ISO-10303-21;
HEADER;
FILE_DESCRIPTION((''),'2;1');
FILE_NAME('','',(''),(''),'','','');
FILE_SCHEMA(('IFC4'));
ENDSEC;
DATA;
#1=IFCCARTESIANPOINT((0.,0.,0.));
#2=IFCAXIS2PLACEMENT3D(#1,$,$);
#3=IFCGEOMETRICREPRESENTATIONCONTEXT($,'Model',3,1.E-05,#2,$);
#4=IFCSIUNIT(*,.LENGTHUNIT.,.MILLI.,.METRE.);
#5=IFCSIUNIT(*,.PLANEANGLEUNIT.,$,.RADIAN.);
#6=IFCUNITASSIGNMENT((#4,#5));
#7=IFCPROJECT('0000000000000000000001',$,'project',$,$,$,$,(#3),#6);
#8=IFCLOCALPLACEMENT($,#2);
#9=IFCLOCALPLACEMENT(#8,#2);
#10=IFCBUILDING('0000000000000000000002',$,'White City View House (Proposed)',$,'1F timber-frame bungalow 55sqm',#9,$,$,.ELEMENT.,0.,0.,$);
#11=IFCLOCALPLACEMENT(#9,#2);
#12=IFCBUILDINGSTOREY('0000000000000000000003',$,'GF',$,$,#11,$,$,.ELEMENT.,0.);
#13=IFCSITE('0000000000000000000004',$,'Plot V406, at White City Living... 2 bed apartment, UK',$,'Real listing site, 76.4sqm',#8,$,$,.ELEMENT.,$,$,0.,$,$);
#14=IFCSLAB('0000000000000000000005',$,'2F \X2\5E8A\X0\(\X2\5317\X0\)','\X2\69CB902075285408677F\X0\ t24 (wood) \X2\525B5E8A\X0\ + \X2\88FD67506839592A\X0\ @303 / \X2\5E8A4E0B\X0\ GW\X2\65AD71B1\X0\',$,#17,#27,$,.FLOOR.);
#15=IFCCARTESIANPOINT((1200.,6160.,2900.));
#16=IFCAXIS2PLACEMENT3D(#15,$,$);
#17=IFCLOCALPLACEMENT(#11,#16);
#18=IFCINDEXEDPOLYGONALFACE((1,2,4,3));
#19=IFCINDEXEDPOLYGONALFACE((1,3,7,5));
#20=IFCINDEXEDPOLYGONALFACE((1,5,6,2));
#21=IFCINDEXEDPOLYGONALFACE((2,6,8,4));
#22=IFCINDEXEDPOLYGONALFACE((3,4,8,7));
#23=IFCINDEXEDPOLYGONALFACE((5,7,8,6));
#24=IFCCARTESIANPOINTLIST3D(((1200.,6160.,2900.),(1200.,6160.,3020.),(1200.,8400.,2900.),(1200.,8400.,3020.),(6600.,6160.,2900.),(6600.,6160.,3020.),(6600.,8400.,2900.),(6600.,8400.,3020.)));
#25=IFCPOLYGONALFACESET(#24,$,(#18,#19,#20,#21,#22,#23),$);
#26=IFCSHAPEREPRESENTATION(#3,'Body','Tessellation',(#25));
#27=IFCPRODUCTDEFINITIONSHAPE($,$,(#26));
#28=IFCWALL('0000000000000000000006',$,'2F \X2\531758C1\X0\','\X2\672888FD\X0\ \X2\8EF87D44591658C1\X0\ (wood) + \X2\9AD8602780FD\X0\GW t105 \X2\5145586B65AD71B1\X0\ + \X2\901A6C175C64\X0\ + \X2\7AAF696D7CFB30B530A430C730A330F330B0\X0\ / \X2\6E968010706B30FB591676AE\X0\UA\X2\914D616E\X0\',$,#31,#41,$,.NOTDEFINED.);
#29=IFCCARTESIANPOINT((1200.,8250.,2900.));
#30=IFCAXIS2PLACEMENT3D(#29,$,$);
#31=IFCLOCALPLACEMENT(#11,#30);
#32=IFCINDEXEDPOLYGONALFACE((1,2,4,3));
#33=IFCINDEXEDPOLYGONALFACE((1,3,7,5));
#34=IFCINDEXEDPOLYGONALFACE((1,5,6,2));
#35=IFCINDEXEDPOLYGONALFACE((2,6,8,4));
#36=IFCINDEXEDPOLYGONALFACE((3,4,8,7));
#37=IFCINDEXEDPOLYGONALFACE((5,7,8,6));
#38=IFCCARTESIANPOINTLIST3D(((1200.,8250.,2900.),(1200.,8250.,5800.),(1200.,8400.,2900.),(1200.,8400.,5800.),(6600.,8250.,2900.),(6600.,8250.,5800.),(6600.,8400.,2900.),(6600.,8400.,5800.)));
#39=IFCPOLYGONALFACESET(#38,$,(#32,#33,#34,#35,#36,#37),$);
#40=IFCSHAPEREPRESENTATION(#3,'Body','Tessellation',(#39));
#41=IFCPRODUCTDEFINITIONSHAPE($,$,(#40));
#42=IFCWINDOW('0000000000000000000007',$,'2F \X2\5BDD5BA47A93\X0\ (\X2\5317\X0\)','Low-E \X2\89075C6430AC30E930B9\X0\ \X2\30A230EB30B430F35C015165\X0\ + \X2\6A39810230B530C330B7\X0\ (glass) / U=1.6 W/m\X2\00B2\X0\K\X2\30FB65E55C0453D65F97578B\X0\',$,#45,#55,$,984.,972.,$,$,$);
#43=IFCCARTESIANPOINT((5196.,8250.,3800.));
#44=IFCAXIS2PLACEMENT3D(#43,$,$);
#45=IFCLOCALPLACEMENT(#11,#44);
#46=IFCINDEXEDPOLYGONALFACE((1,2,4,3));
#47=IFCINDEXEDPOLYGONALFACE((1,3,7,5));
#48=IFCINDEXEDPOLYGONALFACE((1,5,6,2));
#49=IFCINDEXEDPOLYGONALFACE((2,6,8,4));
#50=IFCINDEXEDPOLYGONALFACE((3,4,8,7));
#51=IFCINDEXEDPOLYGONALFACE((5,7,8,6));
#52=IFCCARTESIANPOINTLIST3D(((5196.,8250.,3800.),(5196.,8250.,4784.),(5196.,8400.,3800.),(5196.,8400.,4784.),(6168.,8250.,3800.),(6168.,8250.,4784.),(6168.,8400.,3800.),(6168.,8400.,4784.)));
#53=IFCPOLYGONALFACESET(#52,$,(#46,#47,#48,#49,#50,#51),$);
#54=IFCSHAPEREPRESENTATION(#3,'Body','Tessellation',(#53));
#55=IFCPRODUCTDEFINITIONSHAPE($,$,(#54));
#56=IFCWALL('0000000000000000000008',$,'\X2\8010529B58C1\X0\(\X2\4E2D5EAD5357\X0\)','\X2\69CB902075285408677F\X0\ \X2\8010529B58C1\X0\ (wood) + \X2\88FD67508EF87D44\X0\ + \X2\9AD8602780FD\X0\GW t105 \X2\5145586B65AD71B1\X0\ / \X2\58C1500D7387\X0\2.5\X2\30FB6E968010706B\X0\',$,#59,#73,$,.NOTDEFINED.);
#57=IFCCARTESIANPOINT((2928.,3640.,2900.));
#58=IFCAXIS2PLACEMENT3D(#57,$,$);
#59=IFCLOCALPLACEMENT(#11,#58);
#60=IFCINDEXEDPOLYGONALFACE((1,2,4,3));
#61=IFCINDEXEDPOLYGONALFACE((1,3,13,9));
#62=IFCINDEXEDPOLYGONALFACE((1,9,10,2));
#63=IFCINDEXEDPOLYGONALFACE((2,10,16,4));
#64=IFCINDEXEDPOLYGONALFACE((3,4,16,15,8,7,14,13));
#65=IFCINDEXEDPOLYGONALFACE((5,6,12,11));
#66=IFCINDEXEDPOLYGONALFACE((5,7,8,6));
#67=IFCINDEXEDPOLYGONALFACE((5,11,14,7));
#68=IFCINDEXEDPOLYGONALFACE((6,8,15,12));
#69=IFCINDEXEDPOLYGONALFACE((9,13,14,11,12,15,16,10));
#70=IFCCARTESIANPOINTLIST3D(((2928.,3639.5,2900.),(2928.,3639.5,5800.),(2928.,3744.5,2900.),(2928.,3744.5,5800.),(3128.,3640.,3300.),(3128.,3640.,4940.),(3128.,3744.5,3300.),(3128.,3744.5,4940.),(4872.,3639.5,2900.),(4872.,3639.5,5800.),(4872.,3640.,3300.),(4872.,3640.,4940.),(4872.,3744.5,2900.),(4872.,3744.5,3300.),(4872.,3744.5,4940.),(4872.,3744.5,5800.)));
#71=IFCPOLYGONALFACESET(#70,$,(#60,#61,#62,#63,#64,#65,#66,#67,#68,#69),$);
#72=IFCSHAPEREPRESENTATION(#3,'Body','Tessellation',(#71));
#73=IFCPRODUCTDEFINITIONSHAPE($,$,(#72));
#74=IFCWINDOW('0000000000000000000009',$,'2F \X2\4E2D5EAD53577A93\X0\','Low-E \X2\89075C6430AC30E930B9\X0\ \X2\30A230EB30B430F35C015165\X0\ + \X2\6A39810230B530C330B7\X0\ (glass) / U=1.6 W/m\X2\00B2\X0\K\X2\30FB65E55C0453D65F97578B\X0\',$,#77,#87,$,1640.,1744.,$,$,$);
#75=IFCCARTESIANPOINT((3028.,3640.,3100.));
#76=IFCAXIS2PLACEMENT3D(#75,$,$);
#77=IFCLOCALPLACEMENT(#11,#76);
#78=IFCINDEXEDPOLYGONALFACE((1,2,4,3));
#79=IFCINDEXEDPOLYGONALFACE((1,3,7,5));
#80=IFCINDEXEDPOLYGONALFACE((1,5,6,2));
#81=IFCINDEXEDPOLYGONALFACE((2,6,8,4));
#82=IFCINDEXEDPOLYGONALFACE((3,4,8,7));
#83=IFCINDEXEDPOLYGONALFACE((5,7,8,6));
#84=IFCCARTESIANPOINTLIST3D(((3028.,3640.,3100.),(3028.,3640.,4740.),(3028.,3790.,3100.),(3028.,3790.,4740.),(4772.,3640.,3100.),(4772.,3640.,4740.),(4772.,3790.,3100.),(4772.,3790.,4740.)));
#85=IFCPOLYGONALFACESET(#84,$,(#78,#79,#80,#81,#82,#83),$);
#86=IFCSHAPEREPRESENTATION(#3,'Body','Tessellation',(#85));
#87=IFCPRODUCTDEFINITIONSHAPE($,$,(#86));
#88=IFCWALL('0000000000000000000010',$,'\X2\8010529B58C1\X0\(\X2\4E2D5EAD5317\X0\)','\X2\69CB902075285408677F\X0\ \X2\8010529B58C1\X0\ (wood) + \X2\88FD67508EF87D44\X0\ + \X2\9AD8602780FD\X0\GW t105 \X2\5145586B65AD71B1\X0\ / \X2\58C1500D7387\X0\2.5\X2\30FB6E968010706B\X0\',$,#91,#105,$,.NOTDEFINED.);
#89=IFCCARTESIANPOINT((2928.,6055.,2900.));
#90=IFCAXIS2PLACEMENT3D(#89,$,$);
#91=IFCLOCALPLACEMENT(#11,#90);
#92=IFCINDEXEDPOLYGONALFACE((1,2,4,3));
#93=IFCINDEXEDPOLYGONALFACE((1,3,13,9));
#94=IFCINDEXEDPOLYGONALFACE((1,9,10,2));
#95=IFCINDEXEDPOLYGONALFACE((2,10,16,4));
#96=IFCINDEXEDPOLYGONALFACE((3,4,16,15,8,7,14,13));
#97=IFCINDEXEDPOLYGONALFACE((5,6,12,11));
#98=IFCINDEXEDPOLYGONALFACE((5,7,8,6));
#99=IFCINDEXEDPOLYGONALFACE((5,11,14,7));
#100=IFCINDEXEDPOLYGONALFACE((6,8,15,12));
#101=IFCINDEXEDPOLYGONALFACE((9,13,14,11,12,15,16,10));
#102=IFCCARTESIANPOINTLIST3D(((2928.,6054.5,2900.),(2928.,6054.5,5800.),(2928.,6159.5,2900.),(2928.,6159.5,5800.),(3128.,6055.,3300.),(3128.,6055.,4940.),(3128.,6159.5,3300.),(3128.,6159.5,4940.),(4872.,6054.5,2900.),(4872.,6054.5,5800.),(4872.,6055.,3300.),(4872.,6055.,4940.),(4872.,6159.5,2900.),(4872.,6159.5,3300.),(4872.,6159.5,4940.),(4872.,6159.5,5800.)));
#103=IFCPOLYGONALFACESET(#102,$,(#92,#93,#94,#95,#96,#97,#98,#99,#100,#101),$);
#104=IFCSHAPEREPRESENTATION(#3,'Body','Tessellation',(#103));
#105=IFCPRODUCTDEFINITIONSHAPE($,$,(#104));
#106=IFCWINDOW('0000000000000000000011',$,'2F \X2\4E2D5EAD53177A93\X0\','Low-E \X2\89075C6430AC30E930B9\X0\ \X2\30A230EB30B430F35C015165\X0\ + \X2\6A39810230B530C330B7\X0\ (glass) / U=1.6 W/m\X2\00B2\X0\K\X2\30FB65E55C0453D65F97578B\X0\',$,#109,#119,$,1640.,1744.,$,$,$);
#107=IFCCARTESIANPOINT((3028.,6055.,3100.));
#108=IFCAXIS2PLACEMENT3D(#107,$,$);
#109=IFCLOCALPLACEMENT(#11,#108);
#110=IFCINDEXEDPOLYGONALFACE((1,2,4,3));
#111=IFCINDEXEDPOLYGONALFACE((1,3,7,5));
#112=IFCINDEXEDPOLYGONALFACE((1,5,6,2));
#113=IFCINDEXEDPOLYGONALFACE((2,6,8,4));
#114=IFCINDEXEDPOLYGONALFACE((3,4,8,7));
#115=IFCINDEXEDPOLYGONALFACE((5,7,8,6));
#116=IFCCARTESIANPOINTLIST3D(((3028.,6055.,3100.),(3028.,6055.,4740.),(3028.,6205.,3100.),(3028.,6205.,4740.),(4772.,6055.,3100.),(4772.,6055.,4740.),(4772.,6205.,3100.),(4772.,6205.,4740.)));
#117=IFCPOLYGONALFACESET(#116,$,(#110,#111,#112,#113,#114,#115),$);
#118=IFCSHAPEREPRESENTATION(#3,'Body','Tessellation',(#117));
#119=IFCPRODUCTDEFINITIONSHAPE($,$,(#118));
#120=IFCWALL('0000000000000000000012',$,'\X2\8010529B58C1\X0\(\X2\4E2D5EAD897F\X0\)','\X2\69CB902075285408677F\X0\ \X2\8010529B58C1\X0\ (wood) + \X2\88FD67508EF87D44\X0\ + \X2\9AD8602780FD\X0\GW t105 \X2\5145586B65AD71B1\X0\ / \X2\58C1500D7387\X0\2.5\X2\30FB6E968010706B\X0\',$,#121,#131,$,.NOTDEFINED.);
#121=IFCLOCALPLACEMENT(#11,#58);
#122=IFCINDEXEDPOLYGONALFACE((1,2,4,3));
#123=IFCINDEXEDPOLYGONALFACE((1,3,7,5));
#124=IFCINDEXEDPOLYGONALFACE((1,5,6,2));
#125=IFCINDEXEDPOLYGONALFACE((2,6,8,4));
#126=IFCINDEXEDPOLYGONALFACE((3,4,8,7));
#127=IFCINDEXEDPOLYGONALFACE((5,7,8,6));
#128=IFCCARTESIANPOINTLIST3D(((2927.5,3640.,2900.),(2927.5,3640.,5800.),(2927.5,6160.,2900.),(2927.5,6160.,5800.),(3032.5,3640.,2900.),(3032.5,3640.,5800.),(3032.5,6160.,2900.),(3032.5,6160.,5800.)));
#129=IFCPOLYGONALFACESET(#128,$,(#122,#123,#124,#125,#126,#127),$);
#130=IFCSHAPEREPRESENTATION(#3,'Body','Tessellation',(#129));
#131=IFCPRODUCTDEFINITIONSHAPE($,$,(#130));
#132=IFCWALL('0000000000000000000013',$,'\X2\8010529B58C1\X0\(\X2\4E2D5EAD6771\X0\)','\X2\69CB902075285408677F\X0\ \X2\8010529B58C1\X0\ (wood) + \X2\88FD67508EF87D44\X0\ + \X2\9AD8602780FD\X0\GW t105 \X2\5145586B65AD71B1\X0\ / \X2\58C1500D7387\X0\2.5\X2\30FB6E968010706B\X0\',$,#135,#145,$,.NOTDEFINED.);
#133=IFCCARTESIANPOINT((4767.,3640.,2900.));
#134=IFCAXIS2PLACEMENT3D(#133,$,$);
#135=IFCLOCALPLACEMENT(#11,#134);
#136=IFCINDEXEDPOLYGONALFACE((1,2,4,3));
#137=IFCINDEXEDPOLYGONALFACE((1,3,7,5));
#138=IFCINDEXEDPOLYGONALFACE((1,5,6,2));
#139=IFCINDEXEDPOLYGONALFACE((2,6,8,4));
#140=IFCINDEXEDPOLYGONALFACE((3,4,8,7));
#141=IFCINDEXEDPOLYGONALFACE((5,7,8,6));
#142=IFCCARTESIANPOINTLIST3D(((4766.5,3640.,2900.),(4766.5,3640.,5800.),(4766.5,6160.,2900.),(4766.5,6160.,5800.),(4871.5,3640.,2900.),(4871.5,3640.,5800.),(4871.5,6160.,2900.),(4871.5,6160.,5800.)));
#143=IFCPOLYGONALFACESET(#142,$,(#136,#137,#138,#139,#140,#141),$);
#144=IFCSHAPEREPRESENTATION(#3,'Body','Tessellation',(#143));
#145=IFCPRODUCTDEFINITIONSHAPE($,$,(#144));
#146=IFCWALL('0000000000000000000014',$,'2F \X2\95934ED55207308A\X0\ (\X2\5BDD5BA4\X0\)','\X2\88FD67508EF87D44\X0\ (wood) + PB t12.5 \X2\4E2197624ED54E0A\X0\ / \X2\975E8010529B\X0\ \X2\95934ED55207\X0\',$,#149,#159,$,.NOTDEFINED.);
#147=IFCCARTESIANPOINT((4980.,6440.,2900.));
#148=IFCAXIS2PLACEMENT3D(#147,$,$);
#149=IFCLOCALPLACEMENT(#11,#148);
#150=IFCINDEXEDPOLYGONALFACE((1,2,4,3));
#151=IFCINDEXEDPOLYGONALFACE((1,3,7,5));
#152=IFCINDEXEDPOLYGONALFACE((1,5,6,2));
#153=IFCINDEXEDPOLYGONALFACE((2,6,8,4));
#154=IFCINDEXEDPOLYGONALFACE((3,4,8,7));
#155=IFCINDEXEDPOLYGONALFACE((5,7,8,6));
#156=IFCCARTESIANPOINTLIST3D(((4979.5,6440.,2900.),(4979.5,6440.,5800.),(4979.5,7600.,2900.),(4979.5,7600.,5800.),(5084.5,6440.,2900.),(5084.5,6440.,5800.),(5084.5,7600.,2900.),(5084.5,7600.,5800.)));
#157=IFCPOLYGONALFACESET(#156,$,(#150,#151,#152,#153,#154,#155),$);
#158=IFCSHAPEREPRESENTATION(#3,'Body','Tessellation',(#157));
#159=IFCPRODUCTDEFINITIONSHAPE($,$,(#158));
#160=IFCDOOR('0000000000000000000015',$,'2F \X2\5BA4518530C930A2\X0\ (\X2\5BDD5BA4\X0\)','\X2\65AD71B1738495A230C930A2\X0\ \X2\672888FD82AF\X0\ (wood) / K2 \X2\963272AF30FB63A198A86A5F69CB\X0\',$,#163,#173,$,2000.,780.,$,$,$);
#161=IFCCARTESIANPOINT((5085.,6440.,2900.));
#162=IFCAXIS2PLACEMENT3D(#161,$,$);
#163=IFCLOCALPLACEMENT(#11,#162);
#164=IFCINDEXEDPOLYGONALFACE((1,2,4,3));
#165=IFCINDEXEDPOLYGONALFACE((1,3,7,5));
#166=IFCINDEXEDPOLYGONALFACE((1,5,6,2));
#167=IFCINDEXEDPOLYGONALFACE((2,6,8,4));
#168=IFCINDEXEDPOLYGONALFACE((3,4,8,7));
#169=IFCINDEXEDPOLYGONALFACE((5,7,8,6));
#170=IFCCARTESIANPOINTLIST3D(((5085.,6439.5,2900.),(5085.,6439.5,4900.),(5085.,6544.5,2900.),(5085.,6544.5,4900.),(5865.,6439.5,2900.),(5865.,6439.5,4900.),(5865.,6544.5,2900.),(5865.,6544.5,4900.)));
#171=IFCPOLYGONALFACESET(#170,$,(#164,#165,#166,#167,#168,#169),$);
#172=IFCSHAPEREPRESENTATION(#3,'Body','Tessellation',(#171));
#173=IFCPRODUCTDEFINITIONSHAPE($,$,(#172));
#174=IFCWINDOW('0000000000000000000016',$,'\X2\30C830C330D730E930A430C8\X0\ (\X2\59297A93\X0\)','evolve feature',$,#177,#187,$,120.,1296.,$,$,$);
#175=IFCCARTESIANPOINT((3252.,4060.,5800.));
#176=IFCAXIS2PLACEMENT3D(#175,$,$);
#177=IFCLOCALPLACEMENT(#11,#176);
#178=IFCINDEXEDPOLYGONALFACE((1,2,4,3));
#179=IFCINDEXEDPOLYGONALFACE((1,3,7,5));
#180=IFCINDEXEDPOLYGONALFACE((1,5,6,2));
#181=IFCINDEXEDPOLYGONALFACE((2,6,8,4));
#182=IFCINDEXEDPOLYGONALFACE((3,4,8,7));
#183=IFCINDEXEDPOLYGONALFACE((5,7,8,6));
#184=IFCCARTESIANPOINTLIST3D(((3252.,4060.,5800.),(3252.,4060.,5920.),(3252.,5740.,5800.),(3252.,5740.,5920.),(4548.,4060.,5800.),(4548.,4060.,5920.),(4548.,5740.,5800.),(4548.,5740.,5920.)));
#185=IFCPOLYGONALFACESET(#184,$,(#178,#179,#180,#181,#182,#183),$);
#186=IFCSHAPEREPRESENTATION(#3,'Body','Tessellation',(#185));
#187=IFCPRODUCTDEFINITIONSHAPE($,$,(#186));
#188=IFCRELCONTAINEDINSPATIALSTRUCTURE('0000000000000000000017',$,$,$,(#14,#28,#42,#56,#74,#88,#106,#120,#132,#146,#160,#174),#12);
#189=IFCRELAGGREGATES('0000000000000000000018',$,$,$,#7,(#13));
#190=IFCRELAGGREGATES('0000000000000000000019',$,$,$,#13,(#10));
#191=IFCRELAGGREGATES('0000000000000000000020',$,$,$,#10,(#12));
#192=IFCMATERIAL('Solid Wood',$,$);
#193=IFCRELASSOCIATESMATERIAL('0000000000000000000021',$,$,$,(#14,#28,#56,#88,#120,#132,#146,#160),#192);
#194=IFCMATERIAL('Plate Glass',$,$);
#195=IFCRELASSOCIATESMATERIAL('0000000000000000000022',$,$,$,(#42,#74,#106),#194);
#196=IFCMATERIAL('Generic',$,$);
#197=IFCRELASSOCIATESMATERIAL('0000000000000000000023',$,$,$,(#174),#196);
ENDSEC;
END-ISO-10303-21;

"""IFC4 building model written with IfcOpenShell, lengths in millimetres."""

from ifc_helpers import new_model, si_unit, frame, frame_2d, origin, place, context, project, spatial, rectangle, extrude, material, element, fill, save


model = new_model("IFC4")

# Units and contexts
model_context = context("Model", 3, precision=1e-05, world=origin())
ifc_project = project(units=[si_unit("LENGTHUNIT", "METRE", prefix="MILLI"), si_unit("PLANEANGLEUNIT", "RADIAN")], contexts=[model_context])

# Site, building, storey
site_placement = place(None, origin())
site = spatial("IfcSite", under=ifc_project, at=site_placement, Name="Plot V406, at White City Living... 2 bed apartment, UK", ObjectType="Real listing site, 76.4sqm", CompositionType="ELEMENT", RefElevation=0.0)
building_placement = place(site_placement, origin())
building = spatial("IfcBuilding", under=site, at=building_placement, Name="White City View House (Proposed)", ObjectType="1F timber-frame bungalow 55sqm", CompositionType="ELEMENT", ElevationOfRefHeight=0.0, ElevationOfTerrain=0.0)
storey_placement = place(building_placement, origin())
storey = spatial("IfcBuildingStorey", under=building, at=storey_placement, Name="GF", CompositionType="ELEMENT", Elevation=0.0)

# Slab
ifc_material_1 = material(Name="Solid Wood")
slab_placement = place(storey_placement, frame((1200.0, 6160.0, 2900.0)))
element("IfcSlab", 1, at=slab_placement, inside=storey, material=ifc_material_1, Name="2F 床(北)", Description="構造用合板 t24 (wood) 剛床 + 製材根太 @303 / 床下 GW断熱", PredefinedType="FLOOR", context=model_context, shape_type="SweptSolid", body=[
    extrude(rectangle(XDim=5400.0, YDim=2240.0, at=frame_2d((2700.0, 1120.0))), frame((1200.0, 6160.0, 2900.0)), (0.0, 0.0, 1.0), 120.0),
])

# Walls, openings, windows
wall_1_placement = place(storey_placement, frame((1200.0, 8250.0, 2900.0)))
wall_1 = element("IfcWall", 2, at=wall_1_placement, inside=storey, material=ifc_material_1, Name="2F 北壁", Description="木製 軸組外壁 (wood) + 高性能GW t105 充填断熱 + 通気層 + 窯業系サイディング / 準耐火・外皮UA配慮", PredefinedType="NOTDEFINED", context=model_context, shape_type="SweptSolid", body=[
    extrude(rectangle(XDim=5400.0, YDim=150.0, at=frame_2d((2700.0, 75.0))), frame((1200.0, 8250.0, 2900.0)), (0.0, 0.0, 1.0), 2900.0),
])
opening_1_placement = place(storey_placement, frame((5196.0, 8250.0, 3800.0)))
opening_1 = element("IfcOpeningElement", 3, at=opening_1_placement, cuts=wall_1, PredefinedType="NOTDEFINED", context=model_context, shape_type="SweptSolid", body=[
    extrude(rectangle(XDim=972.0, YDim=150.0, at=frame_2d((486.0, 75.0))), frame((5196.0, 8250.0, 3800.0)), (0.0, 0.0, 1.0), 984.0),
])
ifc_material_2 = material(Name="Plate Glass")
window_1_placement = place(storey_placement, frame((5196.0, 8250.0, 3800.0)))
window_1 = element("IfcWindow", 4, at=window_1_placement, inside=storey, material=ifc_material_2, Name="2F 寝室窓 (北)", Description="Low-E 複層ガラス アルゴン封入 + 樹脂サッシ (glass) / U=1.6 W/m²K・日射取得型", OverallHeight=984.0, OverallWidth=972.0, context=model_context, shape_type="SweptSolid", body=[
    extrude(rectangle(XDim=972.0, YDim=150.0, at=frame_2d((486.0, 75.0))), frame((5196.0, 8250.0, 3800.0)), (0.0, 0.0, 1.0), 984.0),
])
fill(opening_1, window_1)
wall_2_placement = place(storey_placement, frame((2928.0, 3640.0, 2900.0)))
wall_2 = element("IfcWall", 5, at=wall_2_placement, inside=storey, material=ifc_material_1, Name="耐力壁(中庭南)", Description="構造用合板 耐力壁 (wood) + 製材軸組 + 高性能GW t105 充填断熱 / 壁倍率2.5・準耐火", PredefinedType="NOTDEFINED", context=model_context, shape_type="SweptSolid", body=[
    extrude(rectangle(XDim=1944.0, YDim=105.0, at=frame_2d((972.0, 52.0))), frame((2928.0, 3640.0, 2900.0)), (0.0, 0.0, 1.0), 2900.0),
])
opening_2_placement = place(storey_placement, frame((3028.0, 3640.0, 3100.0)))
opening_2 = element("IfcOpeningElement", 6, at=opening_2_placement, cuts=wall_2, PredefinedType="NOTDEFINED", context=model_context, shape_type="SweptSolid", body=[
    extrude(rectangle(XDim=1744.0, YDim=150.0, at=frame_2d((872.0, 75.0))), frame((3028.0, 3640.0, 3100.0)), (0.0, 0.0, 1.0), 1640.0),
])
window_2_placement = place(storey_placement, frame((3028.0, 3640.0, 3100.0)))
window_2 = element("IfcWindow", 7, at=window_2_placement, inside=storey, material=ifc_material_2, Name="2F 中庭南窓", Description="Low-E 複層ガラス アルゴン封入 + 樹脂サッシ (glass) / U=1.6 W/m²K・日射取得型", OverallHeight=1640.0, OverallWidth=1744.0, context=model_context, shape_type="SweptSolid", body=[
    extrude(rectangle(XDim=1744.0, YDim=150.0, at=frame_2d((872.0, 75.0))), frame((3028.0, 3640.0, 3100.0)), (0.0, 0.0, 1.0), 1640.0),
])
fill(opening_2, window_2)
wall_3_placement = place(storey_placement, frame((2928.0, 6055.0, 2900.0)))
wall_3 = element("IfcWall", 8, at=wall_3_placement, inside=storey, material=ifc_material_1, Name="耐力壁(中庭北)", Description="構造用合板 耐力壁 (wood) + 製材軸組 + 高性能GW t105 充填断熱 / 壁倍率2.5・準耐火", PredefinedType="NOTDEFINED", context=model_context, shape_type="SweptSolid", body=[
    extrude(rectangle(XDim=1944.0, YDim=105.0, at=frame_2d((972.0, 52.0))), frame((2928.0, 6055.0, 2900.0)), (0.0, 0.0, 1.0), 2900.0),
])
opening_3_placement = place(storey_placement, frame((3028.0, 6055.0, 3100.0)))
opening_3 = element("IfcOpeningElement", 9, at=opening_3_placement, cuts=wall_3, PredefinedType="NOTDEFINED", context=model_context, shape_type="SweptSolid", body=[
    extrude(rectangle(XDim=1744.0, YDim=150.0, at=frame_2d((872.0, 75.0))), frame((3028.0, 6055.0, 3100.0)), (0.0, 0.0, 1.0), 1640.0),
])
window_3_placement = place(storey_placement, frame((3028.0, 6055.0, 3100.0)))
window_3 = element("IfcWindow", 10, at=window_3_placement, inside=storey, material=ifc_material_2, Name="2F 中庭北窓", Description="Low-E 複層ガラス アルゴン封入 + 樹脂サッシ (glass) / U=1.6 W/m²K・日射取得型", OverallHeight=1640.0, OverallWidth=1744.0, context=model_context, shape_type="SweptSolid", body=[
    extrude(rectangle(XDim=1744.0, YDim=150.0, at=frame_2d((872.0, 75.0))), frame((3028.0, 6055.0, 3100.0)), (0.0, 0.0, 1.0), 1640.0),
])
fill(opening_3, window_3)

# Walls
wall_4_placement = place(storey_placement, frame((2928.0, 3640.0, 2900.0)))
element("IfcWall", 11, at=wall_4_placement, inside=storey, material=ifc_material_1, Name="耐力壁(中庭西)", Description="構造用合板 耐力壁 (wood) + 製材軸組 + 高性能GW t105 充填断熱 / 壁倍率2.5・準耐火", PredefinedType="NOTDEFINED", context=model_context, shape_type="SweptSolid", body=[
    extrude(rectangle(XDim=105.0, YDim=2520.0, at=frame_2d((52.0, 1260.0))), frame((2928.0, 3640.0, 2900.0)), (0.0, 0.0, 1.0), 2900.0),
])
wall_5_placement = place(storey_placement, frame((4767.0, 3640.0, 2900.0)))
element("IfcWall", 12, at=wall_5_placement, inside=storey, material=ifc_material_1, Name="耐力壁(中庭東)", Description="構造用合板 耐力壁 (wood) + 製材軸組 + 高性能GW t105 充填断熱 / 壁倍率2.5・準耐火", PredefinedType="NOTDEFINED", context=model_context, shape_type="SweptSolid", body=[
    extrude(rectangle(XDim=105.0, YDim=2520.0, at=frame_2d((52.0, 1260.0))), frame((4767.0, 3640.0, 2900.0)), (0.0, 0.0, 1.0), 2900.0),
])
wall_6_placement = place(storey_placement, frame((4980.0, 6440.0, 2900.0)))
element("IfcWall", 13, at=wall_6_placement, inside=storey, material=ifc_material_1, Name="2F 間仕切り (寝室)", Description="製材軸組 (wood) + PB t12.5 両面仕上 / 非耐力 間仕切", PredefinedType="NOTDEFINED", context=model_context, shape_type="SweptSolid", body=[
    extrude(rectangle(XDim=105.0, YDim=1160.0, at=frame_2d((52.0, 580.0))), frame((4980.0, 6440.0, 2900.0)), (0.0, 0.0, 1.0), 2900.0),
])

# Door
door_placement = place(storey_placement, frame((5085.0, 6440.0, 2900.0)))
element("IfcDoor", 14, at=door_placement, inside=storey, material=ifc_material_1, Name="2F 室内ドア (寝室)", Description="断熱玄関ドア 木製芯 (wood) / K2 防犯・採風機構", OverallHeight=2000.0, OverallWidth=780.0, context=model_context, shape_type="SweptSolid", body=[
    extrude(rectangle(XDim=780.0, YDim=105.0, at=frame_2d((390.0, 52.0))), frame((5085.0, 6440.0, 2900.0)), (0.0, 0.0, 1.0), 2000.0),
])

# Window
ifc_material_3 = material(Name="Generic")
window_4_placement = place(storey_placement, frame((3252.0, 4060.0, 5800.0)))
element("IfcWindow", 15, at=window_4_placement, inside=storey, material=ifc_material_3, Name="トップライト (天窓)", Description="evolve feature", OverallHeight=120.0, OverallWidth=1296.0, context=model_context, shape_type="SweptSolid", body=[
    extrude(rectangle(XDim=1296.0, YDim=1680.0, at=frame_2d((648.0, 840.0))), frame((3252.0, 4060.0, 5800.0)), (0.0, 0.0, 1.0), 120.0),
])

save(model, "model.ifc")
